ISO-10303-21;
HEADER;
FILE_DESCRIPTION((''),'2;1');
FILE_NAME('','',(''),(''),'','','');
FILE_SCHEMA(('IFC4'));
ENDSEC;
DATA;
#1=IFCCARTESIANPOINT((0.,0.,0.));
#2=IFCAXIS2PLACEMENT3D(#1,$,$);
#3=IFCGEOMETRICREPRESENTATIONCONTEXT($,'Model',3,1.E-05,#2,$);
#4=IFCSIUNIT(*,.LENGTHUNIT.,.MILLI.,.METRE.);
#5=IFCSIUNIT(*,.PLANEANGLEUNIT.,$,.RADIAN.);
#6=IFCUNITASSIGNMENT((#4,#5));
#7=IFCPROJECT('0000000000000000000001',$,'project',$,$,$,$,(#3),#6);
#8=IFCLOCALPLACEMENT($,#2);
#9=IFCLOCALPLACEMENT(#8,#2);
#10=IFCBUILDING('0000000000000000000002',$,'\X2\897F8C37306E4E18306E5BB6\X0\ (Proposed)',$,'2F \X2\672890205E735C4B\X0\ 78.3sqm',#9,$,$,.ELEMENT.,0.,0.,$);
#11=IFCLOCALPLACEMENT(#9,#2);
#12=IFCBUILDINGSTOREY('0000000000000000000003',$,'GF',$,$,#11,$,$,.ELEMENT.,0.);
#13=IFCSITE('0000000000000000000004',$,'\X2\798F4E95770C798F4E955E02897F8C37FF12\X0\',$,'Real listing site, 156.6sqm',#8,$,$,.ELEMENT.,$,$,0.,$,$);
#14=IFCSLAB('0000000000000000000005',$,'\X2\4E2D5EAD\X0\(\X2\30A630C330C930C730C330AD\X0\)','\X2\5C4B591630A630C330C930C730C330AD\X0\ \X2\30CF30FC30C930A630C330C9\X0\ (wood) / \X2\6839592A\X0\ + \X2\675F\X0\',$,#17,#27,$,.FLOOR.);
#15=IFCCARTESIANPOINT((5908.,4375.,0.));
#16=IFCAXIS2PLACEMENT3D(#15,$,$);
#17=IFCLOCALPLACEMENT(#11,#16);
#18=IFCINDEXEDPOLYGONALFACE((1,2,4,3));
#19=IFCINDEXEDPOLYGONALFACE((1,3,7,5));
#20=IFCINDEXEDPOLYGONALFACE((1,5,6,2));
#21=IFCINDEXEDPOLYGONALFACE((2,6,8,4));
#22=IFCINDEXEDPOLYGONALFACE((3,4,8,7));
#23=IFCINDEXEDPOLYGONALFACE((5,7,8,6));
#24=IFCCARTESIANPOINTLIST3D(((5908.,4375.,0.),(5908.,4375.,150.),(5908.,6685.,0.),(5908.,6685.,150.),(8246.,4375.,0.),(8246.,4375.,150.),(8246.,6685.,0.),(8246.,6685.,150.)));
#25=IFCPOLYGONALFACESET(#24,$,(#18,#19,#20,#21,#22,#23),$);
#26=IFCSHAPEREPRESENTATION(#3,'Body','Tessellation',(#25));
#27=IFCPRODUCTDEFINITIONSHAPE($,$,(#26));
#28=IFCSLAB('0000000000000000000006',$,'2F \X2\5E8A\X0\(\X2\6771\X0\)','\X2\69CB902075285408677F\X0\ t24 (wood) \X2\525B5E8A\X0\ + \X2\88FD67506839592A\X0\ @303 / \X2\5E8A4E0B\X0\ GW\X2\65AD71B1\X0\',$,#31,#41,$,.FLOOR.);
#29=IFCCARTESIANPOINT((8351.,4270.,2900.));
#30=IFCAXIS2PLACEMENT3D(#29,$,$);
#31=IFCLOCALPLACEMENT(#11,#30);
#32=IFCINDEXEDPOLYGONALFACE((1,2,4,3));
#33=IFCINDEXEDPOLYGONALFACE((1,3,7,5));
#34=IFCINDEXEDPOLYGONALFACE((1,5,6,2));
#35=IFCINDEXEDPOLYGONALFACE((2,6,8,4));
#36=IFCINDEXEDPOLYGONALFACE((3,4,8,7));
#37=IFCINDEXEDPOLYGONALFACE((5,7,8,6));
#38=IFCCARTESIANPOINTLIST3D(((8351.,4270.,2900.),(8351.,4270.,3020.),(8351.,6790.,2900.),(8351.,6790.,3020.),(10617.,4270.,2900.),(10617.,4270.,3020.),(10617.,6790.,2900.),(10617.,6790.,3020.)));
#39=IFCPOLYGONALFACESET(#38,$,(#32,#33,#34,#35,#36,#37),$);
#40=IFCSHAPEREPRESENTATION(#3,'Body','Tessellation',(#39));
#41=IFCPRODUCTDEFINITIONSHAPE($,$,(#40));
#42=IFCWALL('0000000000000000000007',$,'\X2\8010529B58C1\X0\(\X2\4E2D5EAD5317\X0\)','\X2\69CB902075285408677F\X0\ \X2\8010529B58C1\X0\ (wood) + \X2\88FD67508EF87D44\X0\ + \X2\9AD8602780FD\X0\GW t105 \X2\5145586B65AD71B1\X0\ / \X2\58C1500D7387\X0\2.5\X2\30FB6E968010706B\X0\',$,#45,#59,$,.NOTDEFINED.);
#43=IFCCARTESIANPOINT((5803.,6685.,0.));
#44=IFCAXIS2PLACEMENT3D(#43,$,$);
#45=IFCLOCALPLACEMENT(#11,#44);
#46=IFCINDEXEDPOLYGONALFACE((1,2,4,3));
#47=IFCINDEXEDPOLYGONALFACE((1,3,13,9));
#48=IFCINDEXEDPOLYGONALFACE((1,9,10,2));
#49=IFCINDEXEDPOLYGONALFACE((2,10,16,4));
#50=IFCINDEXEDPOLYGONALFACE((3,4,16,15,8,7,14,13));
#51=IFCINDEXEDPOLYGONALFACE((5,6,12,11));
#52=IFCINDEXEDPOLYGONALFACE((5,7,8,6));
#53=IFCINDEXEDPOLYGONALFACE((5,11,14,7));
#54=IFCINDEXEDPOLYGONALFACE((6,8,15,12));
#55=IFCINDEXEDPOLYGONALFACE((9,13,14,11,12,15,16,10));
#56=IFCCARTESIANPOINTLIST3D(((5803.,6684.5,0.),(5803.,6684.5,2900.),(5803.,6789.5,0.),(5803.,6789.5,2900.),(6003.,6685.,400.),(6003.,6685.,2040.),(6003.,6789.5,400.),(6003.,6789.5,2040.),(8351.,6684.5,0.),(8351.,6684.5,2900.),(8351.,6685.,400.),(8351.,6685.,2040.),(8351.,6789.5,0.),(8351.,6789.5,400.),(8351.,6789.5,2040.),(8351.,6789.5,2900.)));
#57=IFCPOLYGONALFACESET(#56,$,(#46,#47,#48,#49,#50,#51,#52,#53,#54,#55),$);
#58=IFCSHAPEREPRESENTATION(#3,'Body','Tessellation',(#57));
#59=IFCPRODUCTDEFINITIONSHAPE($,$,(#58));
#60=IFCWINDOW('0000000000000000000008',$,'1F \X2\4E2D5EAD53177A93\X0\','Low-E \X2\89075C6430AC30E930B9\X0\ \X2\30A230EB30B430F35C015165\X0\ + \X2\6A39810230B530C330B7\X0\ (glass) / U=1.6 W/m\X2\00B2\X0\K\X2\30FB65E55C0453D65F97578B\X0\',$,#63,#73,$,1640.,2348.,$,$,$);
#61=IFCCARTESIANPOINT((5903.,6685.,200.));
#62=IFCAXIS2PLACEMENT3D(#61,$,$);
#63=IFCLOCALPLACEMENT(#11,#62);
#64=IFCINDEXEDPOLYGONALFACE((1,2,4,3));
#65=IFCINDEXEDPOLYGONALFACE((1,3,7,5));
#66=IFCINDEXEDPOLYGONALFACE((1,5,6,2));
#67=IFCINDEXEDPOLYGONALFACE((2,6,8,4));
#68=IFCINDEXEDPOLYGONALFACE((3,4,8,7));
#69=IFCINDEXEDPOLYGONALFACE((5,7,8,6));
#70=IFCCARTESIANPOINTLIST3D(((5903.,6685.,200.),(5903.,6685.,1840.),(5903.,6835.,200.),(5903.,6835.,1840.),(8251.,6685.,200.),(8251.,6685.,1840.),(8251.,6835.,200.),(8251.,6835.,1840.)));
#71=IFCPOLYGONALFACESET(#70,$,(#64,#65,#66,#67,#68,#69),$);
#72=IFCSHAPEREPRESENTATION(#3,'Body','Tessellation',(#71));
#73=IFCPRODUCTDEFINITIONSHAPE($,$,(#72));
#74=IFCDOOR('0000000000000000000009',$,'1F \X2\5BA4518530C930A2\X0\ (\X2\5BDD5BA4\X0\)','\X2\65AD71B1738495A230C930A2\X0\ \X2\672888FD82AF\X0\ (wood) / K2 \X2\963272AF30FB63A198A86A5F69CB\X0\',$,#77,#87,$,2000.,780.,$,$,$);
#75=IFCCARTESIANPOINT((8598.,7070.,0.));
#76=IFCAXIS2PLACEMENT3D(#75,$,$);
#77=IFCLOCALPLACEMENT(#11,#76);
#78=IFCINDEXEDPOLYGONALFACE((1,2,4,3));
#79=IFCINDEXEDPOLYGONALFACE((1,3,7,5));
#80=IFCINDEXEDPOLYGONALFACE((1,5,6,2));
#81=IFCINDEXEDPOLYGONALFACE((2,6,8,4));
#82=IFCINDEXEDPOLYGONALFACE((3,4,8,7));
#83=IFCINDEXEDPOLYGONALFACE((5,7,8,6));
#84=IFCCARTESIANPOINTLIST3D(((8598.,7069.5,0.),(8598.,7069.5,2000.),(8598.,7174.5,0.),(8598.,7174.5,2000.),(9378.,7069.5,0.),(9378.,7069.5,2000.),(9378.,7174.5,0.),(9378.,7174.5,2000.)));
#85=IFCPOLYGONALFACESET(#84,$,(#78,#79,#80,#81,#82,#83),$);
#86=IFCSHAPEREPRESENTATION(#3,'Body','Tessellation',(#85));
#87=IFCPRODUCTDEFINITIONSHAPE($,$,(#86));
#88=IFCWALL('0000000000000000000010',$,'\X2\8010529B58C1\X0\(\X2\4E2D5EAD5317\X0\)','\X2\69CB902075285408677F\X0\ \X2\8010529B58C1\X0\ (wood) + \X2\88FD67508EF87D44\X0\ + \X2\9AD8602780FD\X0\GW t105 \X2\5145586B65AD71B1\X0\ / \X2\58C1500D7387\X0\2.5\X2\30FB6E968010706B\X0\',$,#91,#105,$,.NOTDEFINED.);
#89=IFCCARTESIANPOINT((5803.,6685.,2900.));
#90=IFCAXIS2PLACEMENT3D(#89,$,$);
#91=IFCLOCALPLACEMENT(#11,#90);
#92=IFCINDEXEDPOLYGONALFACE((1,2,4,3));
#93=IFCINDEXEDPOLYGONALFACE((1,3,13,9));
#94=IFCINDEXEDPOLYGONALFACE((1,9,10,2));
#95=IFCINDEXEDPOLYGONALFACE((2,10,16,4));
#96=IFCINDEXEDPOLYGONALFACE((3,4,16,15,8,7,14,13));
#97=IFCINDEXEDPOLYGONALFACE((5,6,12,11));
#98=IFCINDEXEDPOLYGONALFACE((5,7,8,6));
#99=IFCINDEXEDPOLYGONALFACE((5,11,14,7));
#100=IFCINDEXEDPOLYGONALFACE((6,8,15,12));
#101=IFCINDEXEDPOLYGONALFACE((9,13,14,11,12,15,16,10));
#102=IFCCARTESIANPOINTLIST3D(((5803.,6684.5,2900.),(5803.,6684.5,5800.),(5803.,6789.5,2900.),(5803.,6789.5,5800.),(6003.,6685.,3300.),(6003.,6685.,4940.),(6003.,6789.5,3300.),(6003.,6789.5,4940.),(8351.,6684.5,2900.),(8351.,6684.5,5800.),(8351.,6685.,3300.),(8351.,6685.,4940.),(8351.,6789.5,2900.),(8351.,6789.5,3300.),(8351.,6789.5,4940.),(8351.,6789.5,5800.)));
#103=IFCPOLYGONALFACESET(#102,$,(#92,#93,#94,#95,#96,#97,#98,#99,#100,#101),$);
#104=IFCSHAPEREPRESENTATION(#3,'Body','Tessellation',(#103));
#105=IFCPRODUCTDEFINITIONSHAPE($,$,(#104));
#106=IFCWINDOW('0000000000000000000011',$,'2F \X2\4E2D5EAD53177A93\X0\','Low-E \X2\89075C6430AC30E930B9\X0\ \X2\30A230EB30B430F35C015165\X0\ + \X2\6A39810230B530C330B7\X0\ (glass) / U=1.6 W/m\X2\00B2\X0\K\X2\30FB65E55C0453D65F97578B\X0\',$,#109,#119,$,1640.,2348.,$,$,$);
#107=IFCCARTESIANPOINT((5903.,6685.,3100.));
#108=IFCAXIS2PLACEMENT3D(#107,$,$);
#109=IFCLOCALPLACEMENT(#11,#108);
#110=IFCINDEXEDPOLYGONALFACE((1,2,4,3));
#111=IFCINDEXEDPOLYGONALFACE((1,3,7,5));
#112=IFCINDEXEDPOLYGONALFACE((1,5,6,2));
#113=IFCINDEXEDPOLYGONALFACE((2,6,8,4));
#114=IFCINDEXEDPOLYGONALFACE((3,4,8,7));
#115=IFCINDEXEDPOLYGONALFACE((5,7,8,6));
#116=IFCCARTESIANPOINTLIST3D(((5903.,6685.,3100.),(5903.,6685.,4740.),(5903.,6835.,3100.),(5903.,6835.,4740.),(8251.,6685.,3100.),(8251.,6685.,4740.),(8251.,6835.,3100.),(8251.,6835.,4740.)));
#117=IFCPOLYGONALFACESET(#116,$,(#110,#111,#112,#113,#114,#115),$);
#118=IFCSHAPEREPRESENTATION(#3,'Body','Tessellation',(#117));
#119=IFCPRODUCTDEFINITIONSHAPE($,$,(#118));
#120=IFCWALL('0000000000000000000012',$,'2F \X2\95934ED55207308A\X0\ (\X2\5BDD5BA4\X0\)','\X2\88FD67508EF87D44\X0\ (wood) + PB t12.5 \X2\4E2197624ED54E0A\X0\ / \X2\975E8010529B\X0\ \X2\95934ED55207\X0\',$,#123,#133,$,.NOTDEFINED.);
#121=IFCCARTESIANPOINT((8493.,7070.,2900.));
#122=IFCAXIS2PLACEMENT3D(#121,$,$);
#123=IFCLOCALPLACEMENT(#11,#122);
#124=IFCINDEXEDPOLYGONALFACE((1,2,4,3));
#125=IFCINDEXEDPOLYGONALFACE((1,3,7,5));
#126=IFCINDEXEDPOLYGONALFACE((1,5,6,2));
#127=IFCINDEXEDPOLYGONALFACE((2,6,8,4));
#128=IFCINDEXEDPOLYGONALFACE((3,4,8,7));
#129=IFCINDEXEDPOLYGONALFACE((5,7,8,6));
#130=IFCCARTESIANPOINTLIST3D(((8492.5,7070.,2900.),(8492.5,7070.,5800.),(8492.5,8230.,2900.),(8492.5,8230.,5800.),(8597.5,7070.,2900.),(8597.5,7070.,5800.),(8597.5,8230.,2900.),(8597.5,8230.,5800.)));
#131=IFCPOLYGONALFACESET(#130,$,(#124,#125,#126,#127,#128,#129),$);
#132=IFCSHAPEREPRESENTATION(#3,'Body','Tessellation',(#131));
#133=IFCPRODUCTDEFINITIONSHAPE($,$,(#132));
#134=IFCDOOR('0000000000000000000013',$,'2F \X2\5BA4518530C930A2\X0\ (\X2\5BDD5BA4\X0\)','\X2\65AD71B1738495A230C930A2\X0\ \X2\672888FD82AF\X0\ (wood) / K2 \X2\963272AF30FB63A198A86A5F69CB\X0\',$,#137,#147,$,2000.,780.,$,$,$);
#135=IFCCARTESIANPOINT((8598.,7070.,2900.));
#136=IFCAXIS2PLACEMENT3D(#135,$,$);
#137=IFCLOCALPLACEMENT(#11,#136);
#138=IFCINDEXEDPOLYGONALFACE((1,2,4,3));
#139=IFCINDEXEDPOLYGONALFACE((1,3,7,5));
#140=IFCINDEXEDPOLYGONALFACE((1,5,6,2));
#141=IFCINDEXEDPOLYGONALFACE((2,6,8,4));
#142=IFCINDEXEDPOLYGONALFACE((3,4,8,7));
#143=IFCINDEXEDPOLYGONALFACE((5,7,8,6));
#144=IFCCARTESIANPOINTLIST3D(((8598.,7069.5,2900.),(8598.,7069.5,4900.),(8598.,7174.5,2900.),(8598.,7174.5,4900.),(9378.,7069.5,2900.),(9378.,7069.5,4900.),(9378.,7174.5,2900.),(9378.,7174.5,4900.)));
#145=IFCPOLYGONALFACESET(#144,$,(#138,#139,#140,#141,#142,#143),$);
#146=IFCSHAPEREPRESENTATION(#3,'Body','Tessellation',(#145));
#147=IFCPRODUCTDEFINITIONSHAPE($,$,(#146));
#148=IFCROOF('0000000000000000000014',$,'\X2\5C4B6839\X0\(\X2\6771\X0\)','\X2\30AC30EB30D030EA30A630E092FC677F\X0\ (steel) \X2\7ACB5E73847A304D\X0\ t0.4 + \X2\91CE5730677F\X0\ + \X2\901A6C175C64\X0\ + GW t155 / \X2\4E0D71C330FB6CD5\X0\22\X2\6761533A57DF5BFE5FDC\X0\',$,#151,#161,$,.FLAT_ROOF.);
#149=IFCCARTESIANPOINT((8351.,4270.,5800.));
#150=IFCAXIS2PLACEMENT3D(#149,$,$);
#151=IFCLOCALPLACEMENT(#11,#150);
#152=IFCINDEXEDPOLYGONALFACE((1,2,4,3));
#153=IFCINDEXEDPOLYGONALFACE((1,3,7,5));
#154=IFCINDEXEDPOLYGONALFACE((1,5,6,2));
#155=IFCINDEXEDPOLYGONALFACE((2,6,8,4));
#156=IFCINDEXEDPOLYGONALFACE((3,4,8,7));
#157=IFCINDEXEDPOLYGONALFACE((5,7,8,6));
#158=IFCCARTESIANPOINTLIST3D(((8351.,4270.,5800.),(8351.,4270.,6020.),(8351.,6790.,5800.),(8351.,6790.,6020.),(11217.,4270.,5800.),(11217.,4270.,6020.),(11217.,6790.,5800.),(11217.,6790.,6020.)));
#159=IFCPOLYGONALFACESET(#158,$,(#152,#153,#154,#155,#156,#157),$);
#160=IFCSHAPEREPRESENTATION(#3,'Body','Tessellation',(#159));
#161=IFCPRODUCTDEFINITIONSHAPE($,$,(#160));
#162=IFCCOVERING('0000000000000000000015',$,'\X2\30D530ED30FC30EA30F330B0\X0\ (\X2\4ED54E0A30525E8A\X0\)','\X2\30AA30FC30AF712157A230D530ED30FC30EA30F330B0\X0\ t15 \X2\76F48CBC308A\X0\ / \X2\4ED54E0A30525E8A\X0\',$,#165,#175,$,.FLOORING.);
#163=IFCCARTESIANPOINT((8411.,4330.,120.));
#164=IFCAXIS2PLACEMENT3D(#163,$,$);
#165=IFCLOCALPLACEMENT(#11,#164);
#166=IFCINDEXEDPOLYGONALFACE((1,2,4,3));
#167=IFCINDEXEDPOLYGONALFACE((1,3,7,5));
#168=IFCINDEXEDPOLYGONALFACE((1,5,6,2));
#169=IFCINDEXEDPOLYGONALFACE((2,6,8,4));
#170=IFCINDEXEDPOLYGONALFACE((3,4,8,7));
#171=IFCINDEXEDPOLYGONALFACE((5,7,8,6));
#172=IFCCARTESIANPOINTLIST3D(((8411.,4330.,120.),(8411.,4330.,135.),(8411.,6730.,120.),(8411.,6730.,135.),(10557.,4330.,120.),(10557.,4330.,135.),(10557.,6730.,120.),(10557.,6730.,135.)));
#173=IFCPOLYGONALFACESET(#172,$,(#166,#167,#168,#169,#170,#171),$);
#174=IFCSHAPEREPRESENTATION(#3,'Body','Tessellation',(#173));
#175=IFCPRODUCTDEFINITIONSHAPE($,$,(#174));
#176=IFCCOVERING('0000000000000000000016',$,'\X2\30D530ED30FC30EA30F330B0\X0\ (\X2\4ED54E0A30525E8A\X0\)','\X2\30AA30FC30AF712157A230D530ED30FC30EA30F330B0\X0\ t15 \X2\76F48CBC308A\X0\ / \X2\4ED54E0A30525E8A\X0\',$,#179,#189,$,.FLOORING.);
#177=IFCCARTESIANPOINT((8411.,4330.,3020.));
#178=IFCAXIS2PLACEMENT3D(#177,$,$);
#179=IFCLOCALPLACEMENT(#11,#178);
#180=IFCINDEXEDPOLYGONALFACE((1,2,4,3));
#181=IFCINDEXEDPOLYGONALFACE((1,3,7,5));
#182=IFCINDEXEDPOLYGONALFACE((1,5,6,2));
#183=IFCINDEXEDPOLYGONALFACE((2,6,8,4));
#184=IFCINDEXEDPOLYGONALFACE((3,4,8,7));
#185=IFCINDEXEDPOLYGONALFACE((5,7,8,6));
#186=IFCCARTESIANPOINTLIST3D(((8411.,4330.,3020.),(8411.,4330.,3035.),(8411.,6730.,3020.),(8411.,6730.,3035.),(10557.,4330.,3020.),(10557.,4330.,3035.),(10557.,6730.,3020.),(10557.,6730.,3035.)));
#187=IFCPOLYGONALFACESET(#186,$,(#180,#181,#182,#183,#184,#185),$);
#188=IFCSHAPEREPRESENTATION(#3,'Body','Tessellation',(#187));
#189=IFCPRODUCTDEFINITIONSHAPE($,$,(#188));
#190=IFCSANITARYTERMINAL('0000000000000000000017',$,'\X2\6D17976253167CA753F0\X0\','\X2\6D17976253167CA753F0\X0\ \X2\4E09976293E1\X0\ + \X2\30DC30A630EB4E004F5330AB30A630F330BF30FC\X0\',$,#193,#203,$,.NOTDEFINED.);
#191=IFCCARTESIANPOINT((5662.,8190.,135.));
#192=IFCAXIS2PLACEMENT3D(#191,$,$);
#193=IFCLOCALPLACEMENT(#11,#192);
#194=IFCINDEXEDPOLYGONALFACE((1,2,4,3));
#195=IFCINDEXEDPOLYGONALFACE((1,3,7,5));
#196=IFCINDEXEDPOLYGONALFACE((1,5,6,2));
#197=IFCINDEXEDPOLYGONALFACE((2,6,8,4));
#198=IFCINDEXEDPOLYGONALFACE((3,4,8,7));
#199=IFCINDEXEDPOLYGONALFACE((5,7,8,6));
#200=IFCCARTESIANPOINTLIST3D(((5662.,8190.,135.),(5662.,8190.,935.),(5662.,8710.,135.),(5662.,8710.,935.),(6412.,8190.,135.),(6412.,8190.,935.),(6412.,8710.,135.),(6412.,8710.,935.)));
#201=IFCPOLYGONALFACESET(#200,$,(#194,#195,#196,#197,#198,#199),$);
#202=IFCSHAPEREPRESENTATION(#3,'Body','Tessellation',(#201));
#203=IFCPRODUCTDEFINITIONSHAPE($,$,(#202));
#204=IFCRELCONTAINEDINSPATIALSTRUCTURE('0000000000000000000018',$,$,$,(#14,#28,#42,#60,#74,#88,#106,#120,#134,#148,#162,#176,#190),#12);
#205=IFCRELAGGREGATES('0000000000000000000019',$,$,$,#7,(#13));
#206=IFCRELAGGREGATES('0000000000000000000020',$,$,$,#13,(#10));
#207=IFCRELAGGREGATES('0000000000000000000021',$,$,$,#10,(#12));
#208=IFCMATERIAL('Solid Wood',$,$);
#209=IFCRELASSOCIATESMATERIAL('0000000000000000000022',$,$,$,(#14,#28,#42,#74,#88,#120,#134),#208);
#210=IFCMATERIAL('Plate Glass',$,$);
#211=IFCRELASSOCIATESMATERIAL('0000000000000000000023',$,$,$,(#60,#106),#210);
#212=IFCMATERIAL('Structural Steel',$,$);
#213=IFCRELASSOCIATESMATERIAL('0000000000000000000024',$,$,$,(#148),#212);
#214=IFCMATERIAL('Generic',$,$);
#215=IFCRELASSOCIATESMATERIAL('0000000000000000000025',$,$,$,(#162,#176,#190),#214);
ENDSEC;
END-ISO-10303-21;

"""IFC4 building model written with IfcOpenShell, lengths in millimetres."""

from ifc_helpers import new_model, si_unit, frame, frame_2d, origin, place, context, project, spatial, rectangle, extrude, material, element, fill, save


model = new_model("IFC4")

# Units and contexts
model_context = context("Model", 3, precision=1e-05, world=origin())
ifc_project = project(units=[si_unit("LENGTHUNIT", "METRE", prefix="MILLI"), si_unit("PLANEANGLEUNIT", "RADIAN")], contexts=[model_context])

# Site, building, storey
site_placement = place(None, origin())
site = spatial("IfcSite", under=ifc_project, at=site_placement, Name="福井県福井市西谷２", ObjectType="Real listing site, 156.6sqm", CompositionType="ELEMENT", RefElevation=0.0)
building_placement = place(site_placement, origin())
building = spatial("IfcBuilding", under=site, at=building_placement, Name="西谷の丘の家 (Proposed)", ObjectType="2F 木造平屋 78.3sqm", CompositionType="ELEMENT", ElevationOfRefHeight=0.0, ElevationOfTerrain=0.0)
storey_placement = place(building_placement, origin())
storey = spatial("IfcBuildingStorey", under=building, at=storey_placement, Name="GF", CompositionType="ELEMENT", Elevation=0.0)

# Slabs
ifc_material_1 = material(Name="Solid Wood")
slab_1_placement = place(storey_placement, frame((5908.0, 4375.0, 0.0)))
element("IfcSlab", 1, at=slab_1_placement, inside=storey, material=ifc_material_1, Name="中庭(ウッドデッキ)", Description="屋外ウッドデッキ ハードウッド (wood) / 根太 + 束", PredefinedType="FLOOR", context=model_context, shape_type="SweptSolid", body=[
    extrude(rectangle(XDim=2338.0, YDim=2310.0, at=frame_2d((1169.0, 1155.0))), frame((5908.0, 4375.0, 0.0)), (0.0, 0.0, 1.0), 150.0),
])
slab_2_placement = place(storey_placement, frame((8351.0, 4270.0, 2900.0)))
element("IfcSlab", 2, at=slab_2_placement, inside=storey, material=ifc_material_1, Name="2F 床(東)", Description="構造用合板 t24 (wood) 剛床 + 製材根太 @303 / 床下 GW断熱", PredefinedType="FLOOR", context=model_context, shape_type="SweptSolid", body=[
    extrude(rectangle(XDim=2266.0, YDim=2520.0, at=frame_2d((1133.0, 1260.0))), frame((8351.0, 4270.0, 2900.0)), (0.0, 0.0, 1.0), 120.0),
])

# Wall, opening, window
wall_1_placement = place(storey_placement, frame((5803.0, 6685.0, 0.0)))
wall_1 = element("IfcWall", 3, at=wall_1_placement, inside=storey, material=ifc_material_1, Name="耐力壁(中庭北)", Description="構造用合板 耐力壁 (wood) + 製材軸組 + 高性能GW t105 充填断熱 / 壁倍率2.5・準耐火", PredefinedType="NOTDEFINED", context=model_context, shape_type="SweptSolid", body=[
    extrude(rectangle(XDim=2548.0, YDim=105.0, at=frame_2d((1274.0, 52.0))), frame((5803.0, 6685.0, 0.0)), (0.0, 0.0, 1.0), 2900.0),
])
opening_1_placement = place(storey_placement, frame((5903.0, 6685.0, 200.0)))
opening_1 = element("IfcOpeningElement", 4, at=opening_1_placement, cuts=wall_1, PredefinedType="NOTDEFINED", context=model_context, shape_type="SweptSolid", body=[
    extrude(rectangle(XDim=2348.0, YDim=150.0, at=frame_2d((1174.0, 75.0))), frame((5903.0, 6685.0, 200.0)), (0.0, 0.0, 1.0), 1640.0),
])
ifc_material_2 = material(Name="Plate Glass")
window_1_placement = place(storey_placement, frame((5903.0, 6685.0, 200.0)))
window_1 = element("IfcWindow", 5, at=window_1_placement, inside=storey, material=ifc_material_2, Name="1F 中庭北窓", Description="Low-E 複層ガラス アルゴン封入 + 樹脂サッシ (glass) / U=1.6 W/m²K・日射取得型", OverallHeight=1640.0, OverallWidth=2348.0, context=model_context, shape_type="SweptSolid", body=[
    extrude(rectangle(XDim=2348.0, YDim=150.0, at=frame_2d((1174.0, 75.0))), frame((5903.0, 6685.0, 200.0)), (0.0, 0.0, 1.0), 1640.0),
])
fill(opening_1, window_1)

# Door
door_1_placement = place(storey_placement, frame((8598.0, 7070.0, 0.0)))
element("IfcDoor", 6, at=door_1_placement, inside=storey, material=ifc_material_1, Name="1F 室内ドア (寝室)", Description="断熱玄関ドア 木製芯 (wood) / K2 防犯・採風機構", OverallHeight=2000.0, OverallWidth=780.0, context=model_context, shape_type="SweptSolid", body=[
    extrude(rectangle(XDim=780.0, YDim=105.0, at=frame_2d((390.0, 52.0))), frame((8598.0, 7070.0, 0.0)), (0.0, 0.0, 1.0), 2000.0),
])

# Wall, opening, window
wall_2_placement = place(storey_placement, frame((5803.0, 6685.0, 2900.0)))
wall_2 = element("IfcWall", 7, at=wall_2_placement, inside=storey, material=ifc_material_1, Name="耐力壁(中庭北)", Description="構造用合板 耐力壁 (wood) + 製材軸組 + 高性能GW t105 充填断熱 / 壁倍率2.5・準耐火", PredefinedType="NOTDEFINED", context=model_context, shape_type="SweptSolid", body=[
    extrude(rectangle(XDim=2548.0, YDim=105.0, at=frame_2d((1274.0, 52.0))), frame((5803.0, 6685.0, 2900.0)), (0.0, 0.0, 1.0), 2900.0),
])
opening_2_placement = place(storey_placement, frame((5903.0, 6685.0, 3100.0)))
opening_2 = element("IfcOpeningElement", 8, at=opening_2_placement, cuts=wall_2, PredefinedType="NOTDEFINED", context=model_context, shape_type="SweptSolid", body=[
    extrude(rectangle(XDim=2348.0, YDim=150.0, at=frame_2d((1174.0, 75.0))), frame((5903.0, 6685.0, 3100.0)), (0.0, 0.0, 1.0), 1640.0),
])
window_2_placement = place(storey_placement, frame((5903.0, 6685.0, 3100.0)))
window_2 = element("IfcWindow", 9, at=window_2_placement, inside=storey, material=ifc_material_2, Name="2F 中庭北窓", Description="Low-E 複層ガラス アルゴン封入 + 樹脂サッシ (glass) / U=1.6 W/m²K・日射取得型", OverallHeight=1640.0, OverallWidth=2348.0, context=model_context, shape_type="SweptSolid", body=[
    extrude(rectangle(XDim=2348.0, YDim=150.0, at=frame_2d((1174.0, 75.0))), frame((5903.0, 6685.0, 3100.0)), (0.0, 0.0, 1.0), 1640.0),
])
fill(opening_2, window_2)

# Wall
wall_3_placement = place(storey_placement, frame((8493.0, 7070.0, 2900.0)))
element("IfcWall", 10, at=wall_3_placement, inside=storey, material=ifc_material_1, Name="2F 間仕切り (寝室)", Description="製材軸組 (wood) + PB t12.5 両面仕上 / 非耐力 間仕切", PredefinedType="NOTDEFINED", context=model_context, shape_type="SweptSolid", body=[
    extrude(rectangle(XDim=105.0, YDim=1160.0, at=frame_2d((52.0, 580.0))), frame((8493.0, 7070.0, 2900.0)), (0.0, 0.0, 1.0), 2900.0),
])

# Door
door_2_placement = place(storey_placement, frame((8598.0, 7070.0, 2900.0)))
element("IfcDoor", 11, at=door_2_placement, inside=storey, material=ifc_material_1, Name="2F 室内ドア (寝室)", Description="断熱玄関ドア 木製芯 (wood) / K2 防犯・採風機構", OverallHeight=2000.0, OverallWidth=780.0, context=model_context, shape_type="SweptSolid", body=[
    extrude(rectangle(XDim=780.0, YDim=105.0, at=frame_2d((390.0, 52.0))), frame((8598.0, 7070.0, 2900.0)), (0.0, 0.0, 1.0), 2000.0),
])

# Roof
ifc_material_3 = material(Name="Structural Steel")
for number, where, name in (
    (12, (8351.0, 4270.0, 5800.0), "屋根(東)"),
):
    element("IfcRoof", number, at=place(storey_placement, frame(where)), inside=storey, material=ifc_material_3, Name=name, Description="ガルバリウム鋼板 (steel) 立平葺き t0.4 + 野地板 + 通気層 + GW t155 / 不燃・法22条区域対応", PredefinedType="FLAT_ROOF", context=model_context, shape_type="SweptSolid", body=[
        extrude(rectangle(XDim=2866.0, YDim=2520.0, at=frame_2d((1433.0, 1260.0))), frame((8351.0, 4270.0, 5800.0)), (0.0, 0.0, 1.0), 220.0),
    ])

# Coverings
ifc_material_4 = material(Name="Generic")
covering_1_placement = place(storey_placement, frame((8411.0, 4330.0, 120.0)))
element("IfcCovering", 13, at=covering_1_placement, inside=storey, material=ifc_material_4, Name="フローリング (仕上げ床)", Description="オーク無垢フローリング t15 直貼り / 仕上げ床", PredefinedType="FLOORING", context=model_context, shape_type="SweptSolid", body=[
    extrude(rectangle(XDim=2146.0, YDim=2400.0, at=frame_2d((1073.0, 1200.0))), frame((8411.0, 4330.0, 120.0)), (0.0, 0.0, 1.0), 15.0),
])
covering_2_placement = place(storey_placement, frame((8411.0, 4330.0, 3020.0)))
element("IfcCovering", 14, at=covering_2_placement, inside=storey, material=ifc_material_4, Name="フローリング (仕上げ床)", Description="オーク無垢フローリング t15 直貼り / 仕上げ床", PredefinedType="FLOORING", context=model_context, shape_type="SweptSolid", body=[
    extrude(rectangle(XDim=2146.0, YDim=2400.0, at=frame_2d((1073.0, 1200.0))), frame((8411.0, 4330.0, 3020.0)), (0.0, 0.0, 1.0), 15.0),
])

# Sanitary terminal
sanitary_terminal_1_placement = place(storey_placement, frame((5662.0, 8190.0, 135.0)))
element("IfcSanitaryTerminal", 15, at=sanitary_terminal_1_placement, inside=storey, material=ifc_material_4, Name="洗面化粧台", Description="洗面化粧台 三面鏡 + ボウル一体カウンター", PredefinedType="NOTDEFINED", context=model_context, shape_type="SweptSolid", body=[
    extrude(rectangle(XDim=750.0, YDim=520.0, at=frame_2d((375.0, 260.0))), frame((5662.0, 8190.0, 135.0)), (0.0, 0.0, 1.0), 800.0),
])

save(model, "model.ifc")
